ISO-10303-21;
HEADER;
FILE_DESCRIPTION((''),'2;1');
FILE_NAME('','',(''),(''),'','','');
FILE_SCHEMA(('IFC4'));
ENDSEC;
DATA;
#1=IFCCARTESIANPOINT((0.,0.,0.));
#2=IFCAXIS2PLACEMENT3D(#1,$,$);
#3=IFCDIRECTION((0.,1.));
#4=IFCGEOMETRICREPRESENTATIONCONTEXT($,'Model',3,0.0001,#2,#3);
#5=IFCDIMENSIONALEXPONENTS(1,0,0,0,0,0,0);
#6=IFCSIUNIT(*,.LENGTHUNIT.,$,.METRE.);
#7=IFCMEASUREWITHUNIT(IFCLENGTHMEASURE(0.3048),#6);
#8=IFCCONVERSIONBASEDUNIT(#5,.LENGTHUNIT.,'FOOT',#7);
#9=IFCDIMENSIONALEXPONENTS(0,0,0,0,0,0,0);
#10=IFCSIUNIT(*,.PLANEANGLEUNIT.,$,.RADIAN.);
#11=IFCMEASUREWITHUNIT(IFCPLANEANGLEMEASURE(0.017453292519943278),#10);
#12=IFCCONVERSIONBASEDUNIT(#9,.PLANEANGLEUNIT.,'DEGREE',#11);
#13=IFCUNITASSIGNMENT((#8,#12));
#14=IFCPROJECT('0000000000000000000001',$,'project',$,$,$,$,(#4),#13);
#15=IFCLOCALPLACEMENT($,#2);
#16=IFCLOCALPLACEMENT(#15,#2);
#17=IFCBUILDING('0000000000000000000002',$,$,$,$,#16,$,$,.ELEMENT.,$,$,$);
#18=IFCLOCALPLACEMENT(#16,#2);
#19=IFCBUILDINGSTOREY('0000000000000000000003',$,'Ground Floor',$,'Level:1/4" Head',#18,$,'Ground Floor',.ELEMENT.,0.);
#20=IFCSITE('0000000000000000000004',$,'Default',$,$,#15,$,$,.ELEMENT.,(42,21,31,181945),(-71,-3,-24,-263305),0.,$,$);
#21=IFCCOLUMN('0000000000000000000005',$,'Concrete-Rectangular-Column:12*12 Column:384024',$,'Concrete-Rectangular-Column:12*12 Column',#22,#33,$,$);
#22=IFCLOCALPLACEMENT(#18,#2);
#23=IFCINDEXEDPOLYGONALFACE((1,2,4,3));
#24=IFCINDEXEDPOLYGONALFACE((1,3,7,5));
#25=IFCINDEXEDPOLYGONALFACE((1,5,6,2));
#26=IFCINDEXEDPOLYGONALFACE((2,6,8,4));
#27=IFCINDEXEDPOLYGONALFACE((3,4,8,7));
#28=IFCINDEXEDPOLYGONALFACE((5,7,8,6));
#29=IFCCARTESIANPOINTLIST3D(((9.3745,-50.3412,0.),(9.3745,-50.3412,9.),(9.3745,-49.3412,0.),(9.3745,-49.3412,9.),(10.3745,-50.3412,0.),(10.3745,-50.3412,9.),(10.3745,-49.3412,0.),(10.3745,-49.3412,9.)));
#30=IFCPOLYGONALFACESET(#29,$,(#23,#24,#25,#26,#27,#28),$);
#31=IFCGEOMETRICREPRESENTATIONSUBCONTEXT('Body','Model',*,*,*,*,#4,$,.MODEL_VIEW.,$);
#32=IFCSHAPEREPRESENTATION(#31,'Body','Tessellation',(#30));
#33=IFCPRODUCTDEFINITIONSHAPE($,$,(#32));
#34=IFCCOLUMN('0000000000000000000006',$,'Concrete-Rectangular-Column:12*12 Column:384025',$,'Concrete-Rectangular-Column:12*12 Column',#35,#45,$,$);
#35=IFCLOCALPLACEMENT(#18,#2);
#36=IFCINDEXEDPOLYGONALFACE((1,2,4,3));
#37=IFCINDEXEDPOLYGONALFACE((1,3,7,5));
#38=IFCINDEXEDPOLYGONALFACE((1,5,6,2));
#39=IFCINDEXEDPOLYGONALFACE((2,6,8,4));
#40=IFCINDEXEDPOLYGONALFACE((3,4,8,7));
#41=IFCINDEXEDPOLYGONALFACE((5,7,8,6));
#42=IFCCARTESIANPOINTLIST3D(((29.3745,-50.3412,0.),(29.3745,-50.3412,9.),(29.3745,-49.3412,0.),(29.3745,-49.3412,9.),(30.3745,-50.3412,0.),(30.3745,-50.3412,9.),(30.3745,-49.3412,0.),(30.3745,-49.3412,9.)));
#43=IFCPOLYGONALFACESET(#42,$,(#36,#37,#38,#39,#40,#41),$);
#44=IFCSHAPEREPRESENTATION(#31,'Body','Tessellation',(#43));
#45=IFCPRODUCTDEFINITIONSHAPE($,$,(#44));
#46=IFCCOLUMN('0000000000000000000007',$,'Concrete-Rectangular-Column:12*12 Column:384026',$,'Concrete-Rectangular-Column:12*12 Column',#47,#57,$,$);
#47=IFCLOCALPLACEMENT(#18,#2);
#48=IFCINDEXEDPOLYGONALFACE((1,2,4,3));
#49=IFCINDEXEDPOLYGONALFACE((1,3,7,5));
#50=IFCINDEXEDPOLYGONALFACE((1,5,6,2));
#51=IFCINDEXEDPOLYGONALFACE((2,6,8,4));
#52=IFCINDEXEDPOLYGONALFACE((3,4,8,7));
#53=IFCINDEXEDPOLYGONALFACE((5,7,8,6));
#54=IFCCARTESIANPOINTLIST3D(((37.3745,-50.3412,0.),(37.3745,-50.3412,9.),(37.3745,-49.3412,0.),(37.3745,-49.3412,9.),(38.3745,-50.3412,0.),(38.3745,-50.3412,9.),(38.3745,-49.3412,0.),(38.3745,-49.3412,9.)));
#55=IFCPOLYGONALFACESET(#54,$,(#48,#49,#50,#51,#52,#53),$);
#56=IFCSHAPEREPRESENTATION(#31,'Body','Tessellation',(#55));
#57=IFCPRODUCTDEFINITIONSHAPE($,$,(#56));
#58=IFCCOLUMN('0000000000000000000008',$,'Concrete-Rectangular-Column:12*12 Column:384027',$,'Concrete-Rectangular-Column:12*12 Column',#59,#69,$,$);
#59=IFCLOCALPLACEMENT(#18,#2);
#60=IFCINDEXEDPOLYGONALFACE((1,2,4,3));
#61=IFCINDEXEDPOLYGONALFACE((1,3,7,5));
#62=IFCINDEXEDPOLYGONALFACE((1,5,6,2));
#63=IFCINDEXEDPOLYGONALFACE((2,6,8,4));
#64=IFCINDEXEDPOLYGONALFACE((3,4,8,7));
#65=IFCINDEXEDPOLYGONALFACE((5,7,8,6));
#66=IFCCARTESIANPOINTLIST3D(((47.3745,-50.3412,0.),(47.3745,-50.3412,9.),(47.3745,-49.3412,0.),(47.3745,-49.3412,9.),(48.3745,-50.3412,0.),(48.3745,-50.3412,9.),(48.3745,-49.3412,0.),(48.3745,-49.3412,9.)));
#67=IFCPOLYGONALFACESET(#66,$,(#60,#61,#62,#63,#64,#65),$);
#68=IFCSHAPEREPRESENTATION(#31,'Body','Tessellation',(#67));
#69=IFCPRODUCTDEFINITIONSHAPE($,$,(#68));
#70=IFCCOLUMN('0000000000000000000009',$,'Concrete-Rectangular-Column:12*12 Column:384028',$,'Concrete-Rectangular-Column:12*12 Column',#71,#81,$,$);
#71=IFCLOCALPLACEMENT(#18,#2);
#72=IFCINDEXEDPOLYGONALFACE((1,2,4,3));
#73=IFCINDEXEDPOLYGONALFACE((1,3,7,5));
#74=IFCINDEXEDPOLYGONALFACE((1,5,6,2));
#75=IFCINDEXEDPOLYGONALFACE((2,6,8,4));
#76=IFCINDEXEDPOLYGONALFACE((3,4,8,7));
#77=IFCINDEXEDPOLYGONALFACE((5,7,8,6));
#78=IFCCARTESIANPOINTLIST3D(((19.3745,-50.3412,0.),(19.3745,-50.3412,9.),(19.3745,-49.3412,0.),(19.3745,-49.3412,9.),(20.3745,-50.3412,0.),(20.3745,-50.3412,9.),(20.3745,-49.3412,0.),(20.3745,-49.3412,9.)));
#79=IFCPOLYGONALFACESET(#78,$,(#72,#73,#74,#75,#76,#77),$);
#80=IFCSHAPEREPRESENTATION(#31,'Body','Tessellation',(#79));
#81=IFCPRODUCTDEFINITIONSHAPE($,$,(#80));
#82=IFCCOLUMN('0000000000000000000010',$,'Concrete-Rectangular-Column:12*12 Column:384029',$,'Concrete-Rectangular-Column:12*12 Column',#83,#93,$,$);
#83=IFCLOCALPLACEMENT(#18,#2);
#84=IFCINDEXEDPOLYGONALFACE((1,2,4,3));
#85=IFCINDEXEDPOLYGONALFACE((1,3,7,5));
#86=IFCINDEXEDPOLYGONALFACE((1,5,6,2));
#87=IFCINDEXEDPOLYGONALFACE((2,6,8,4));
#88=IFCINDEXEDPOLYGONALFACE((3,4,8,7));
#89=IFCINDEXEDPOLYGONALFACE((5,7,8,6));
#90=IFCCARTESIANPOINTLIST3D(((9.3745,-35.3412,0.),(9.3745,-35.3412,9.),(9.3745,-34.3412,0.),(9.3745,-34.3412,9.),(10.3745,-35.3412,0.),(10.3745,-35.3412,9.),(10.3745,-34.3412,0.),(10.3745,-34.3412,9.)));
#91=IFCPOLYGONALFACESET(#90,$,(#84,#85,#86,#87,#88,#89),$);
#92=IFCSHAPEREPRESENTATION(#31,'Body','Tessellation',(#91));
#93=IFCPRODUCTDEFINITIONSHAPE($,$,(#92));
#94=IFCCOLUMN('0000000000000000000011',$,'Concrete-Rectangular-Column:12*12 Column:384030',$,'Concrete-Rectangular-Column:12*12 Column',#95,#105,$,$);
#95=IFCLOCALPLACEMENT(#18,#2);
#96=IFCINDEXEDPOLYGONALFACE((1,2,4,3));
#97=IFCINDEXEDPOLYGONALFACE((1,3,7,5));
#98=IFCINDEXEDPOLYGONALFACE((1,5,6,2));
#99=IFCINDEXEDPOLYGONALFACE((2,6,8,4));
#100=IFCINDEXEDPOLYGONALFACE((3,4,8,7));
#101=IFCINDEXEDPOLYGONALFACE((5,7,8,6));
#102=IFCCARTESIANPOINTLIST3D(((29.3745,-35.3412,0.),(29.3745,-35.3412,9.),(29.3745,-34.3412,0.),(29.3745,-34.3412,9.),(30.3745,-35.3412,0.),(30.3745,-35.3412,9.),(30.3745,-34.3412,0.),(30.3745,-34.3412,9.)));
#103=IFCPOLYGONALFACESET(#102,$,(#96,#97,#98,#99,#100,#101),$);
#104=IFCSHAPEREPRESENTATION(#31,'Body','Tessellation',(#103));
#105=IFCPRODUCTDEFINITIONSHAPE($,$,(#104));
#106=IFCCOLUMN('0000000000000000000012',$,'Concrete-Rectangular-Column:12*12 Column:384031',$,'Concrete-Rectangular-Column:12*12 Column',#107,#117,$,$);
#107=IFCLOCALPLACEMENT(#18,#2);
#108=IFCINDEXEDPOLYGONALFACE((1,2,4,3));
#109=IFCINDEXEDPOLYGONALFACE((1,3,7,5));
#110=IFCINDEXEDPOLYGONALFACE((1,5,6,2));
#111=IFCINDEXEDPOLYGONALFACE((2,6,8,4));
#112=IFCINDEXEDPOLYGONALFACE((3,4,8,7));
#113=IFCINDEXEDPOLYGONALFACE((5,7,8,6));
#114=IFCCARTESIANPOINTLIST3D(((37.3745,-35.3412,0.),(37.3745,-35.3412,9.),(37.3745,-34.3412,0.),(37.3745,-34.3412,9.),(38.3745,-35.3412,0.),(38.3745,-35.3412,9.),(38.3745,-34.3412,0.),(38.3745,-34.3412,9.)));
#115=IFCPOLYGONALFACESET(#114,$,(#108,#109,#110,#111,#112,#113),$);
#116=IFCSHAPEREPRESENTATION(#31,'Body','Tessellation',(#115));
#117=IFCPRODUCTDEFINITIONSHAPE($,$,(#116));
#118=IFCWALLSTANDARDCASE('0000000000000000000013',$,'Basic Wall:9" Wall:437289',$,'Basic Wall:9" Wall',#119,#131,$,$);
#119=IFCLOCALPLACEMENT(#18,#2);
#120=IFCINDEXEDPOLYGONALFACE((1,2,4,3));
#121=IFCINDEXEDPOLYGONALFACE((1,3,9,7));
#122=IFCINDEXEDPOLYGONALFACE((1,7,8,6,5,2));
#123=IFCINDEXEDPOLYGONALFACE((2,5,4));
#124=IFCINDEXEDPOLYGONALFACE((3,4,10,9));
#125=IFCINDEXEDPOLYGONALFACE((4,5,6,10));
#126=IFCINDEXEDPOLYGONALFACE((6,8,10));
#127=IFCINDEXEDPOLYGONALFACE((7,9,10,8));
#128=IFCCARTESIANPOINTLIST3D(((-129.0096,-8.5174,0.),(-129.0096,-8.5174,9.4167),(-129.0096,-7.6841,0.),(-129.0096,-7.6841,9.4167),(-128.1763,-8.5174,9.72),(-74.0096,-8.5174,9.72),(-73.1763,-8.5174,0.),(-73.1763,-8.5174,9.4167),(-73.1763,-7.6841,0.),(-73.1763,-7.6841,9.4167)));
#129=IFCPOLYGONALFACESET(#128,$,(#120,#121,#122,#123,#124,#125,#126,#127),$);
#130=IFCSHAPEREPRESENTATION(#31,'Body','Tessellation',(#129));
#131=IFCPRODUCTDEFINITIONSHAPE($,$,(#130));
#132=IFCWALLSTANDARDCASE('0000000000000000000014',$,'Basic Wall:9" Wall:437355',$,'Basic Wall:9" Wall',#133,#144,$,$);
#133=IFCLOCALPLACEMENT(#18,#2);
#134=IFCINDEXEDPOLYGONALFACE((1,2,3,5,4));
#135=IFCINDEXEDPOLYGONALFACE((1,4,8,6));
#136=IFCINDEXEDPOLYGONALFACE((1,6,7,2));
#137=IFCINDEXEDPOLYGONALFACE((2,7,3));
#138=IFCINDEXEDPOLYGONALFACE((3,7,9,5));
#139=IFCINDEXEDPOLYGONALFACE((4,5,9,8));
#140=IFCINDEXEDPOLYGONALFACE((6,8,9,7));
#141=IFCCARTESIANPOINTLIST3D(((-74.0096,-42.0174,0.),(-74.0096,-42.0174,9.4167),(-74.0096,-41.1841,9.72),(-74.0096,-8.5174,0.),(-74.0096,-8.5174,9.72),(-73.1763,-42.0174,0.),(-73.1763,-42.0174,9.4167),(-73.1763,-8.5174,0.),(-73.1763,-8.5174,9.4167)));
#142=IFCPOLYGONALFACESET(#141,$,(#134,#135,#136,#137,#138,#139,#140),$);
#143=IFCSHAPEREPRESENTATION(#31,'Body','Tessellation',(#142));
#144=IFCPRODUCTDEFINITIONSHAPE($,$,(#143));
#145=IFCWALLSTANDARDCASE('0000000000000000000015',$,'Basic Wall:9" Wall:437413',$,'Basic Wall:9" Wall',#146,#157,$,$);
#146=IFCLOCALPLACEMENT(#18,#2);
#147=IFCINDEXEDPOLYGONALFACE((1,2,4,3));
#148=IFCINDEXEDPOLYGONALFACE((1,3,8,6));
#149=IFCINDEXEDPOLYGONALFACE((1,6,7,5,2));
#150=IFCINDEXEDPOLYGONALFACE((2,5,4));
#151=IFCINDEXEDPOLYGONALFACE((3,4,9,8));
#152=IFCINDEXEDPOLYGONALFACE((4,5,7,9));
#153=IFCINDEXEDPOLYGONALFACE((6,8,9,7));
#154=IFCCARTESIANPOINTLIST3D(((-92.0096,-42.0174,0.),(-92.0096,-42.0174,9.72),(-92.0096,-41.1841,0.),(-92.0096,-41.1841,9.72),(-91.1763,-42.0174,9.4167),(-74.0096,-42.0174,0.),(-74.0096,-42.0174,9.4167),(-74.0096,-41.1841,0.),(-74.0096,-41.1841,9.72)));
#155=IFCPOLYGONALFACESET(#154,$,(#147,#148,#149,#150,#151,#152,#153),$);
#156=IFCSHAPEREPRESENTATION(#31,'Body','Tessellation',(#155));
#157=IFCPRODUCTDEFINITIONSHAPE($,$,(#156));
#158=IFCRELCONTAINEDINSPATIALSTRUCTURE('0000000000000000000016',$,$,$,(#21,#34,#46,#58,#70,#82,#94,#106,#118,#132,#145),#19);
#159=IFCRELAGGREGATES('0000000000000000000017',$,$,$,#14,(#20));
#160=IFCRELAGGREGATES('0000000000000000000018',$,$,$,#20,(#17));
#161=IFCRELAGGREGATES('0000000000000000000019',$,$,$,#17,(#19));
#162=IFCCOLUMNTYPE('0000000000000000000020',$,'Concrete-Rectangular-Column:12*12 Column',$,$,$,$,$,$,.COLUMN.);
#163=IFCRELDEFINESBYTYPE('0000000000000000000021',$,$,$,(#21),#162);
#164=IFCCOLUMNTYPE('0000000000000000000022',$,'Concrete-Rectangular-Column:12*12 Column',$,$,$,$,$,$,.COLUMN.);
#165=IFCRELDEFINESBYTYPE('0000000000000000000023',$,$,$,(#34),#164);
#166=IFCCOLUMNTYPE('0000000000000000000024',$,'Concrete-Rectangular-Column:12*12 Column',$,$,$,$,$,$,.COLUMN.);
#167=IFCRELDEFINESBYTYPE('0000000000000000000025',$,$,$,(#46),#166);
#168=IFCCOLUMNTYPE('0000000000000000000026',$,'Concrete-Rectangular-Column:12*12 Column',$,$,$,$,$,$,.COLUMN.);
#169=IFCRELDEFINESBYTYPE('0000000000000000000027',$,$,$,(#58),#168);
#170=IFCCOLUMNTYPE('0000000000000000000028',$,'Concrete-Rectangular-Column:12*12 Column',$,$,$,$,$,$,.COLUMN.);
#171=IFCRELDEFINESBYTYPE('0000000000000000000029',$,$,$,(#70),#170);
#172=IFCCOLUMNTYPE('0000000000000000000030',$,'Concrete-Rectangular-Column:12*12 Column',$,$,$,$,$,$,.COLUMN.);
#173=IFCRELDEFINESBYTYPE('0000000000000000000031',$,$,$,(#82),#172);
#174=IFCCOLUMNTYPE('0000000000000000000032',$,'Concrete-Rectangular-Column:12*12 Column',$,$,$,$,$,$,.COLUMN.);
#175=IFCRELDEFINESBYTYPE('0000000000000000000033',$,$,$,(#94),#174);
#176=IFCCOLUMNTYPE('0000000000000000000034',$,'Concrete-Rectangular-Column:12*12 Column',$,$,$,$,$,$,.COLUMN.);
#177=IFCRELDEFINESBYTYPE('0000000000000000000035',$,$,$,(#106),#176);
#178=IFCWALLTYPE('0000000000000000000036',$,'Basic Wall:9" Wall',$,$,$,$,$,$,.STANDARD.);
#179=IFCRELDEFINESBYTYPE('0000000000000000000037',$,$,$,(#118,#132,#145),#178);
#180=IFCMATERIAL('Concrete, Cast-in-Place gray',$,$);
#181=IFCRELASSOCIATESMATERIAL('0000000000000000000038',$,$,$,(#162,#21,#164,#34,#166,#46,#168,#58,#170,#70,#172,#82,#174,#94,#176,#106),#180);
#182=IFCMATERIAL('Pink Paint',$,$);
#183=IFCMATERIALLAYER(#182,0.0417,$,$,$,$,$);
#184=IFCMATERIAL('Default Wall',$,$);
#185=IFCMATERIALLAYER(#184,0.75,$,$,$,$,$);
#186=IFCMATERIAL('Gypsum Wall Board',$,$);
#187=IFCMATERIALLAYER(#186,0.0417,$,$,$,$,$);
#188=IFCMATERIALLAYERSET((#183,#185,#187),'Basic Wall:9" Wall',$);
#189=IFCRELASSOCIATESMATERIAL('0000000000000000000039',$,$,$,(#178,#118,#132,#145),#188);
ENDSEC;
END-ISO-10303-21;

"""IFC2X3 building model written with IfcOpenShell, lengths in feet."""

from ifc_helpers import new_model, entity, si_unit, converted_unit, direction, frame, frame_2d, origin, origin_2d_with_axis, place, context, subcontext, project, spatial, polyline, rectangle, extrude, clip, bounded_halfspace, source, transform, mapped, material, layer, layer_set, layer_usage, type_object, type_shapes, element, save


model = new_model("IFC2X3")

# Units and contexts
model_context = context("Model", 3, precision=0.0001, world=origin(), true_north=direction((0.0, 1.0)))
body_context = subcontext(model_context, "Body", "Model", "MODEL_VIEW")
ifc_project = project(units=[converted_unit("LENGTHUNIT", "FOOT", entity("IfcLengthMeasure", 0.3048), si_unit("LENGTHUNIT", "METRE"), dimensions=[1, 0, 0, 0, 0, 0, 0]), converted_unit("PLANEANGLEUNIT", "DEGREE", entity("IfcPlaneAngleMeasure", 0.017453292519943278), si_unit("PLANEANGLEUNIT", "RADIAN"), dimensions=[0, 0, 0, 0, 0, 0, 0])], contexts=[model_context])

# Site, building, storey
site_placement = place(None, origin())
site = spatial("IfcSite", under=ifc_project, at=site_placement, Name="Default", CompositionType="ELEMENT", RefLatitude=(42, 21, 31, 181945), RefLongitude=(-71, -3, -24, -263305), RefElevation=0.0)
building_placement = place(site_placement, origin())
building = spatial("IfcBuilding", under=site, at=building_placement, CompositionType="ELEMENT")
storey_placement = place(building_placement, origin())
storey = spatial("IfcBuildingStorey", under=building, at=storey_placement, Name="Ground Floor", ObjectType="Level:1/4\" Head", LongName="Ground Floor", CompositionType="ELEMENT", Elevation=0.0)

# Columns
ifc_material_1 = material(Name="Concrete, Cast-in-Place gray")
column_type_1 = type_object("IfcColumnType", Name="Concrete-Rectangular-Column:12*12 Column", PredefinedType="COLUMN", material=ifc_material_1)
shared_shape_1 = source(origin(), body_context, "Body", "SweptSolid", [
    extrude(rectangle(XDim=1.0, YDim=1.0, at=origin_2d_with_axis()), frame((9.8745, -49.8412, 0.0), z_axis=(0.0, 0.0, 1.0), x_axis=(-1.0, 0.0, 0.0)), (0.0, 0.0, 1.0), 9.0),
])
type_shapes(column_type_1, [shared_shape_1])
column_1_placement = place(storey_placement, origin())
element("IfcColumn", 1, at=column_1_placement, inside=storey, type_object=column_type_1, material=ifc_material_1, Name="Concrete-Rectangular-Column:12*12 Column:384024", ObjectType="Concrete-Rectangular-Column:12*12 Column", context=body_context, shape_type="MappedRepresentation", body=[
    mapped(shared_shape_1, transform((0.0, 0.0, 0.0), scale=1.0)),
])
column_type_2 = type_object("IfcColumnType", Name="Concrete-Rectangular-Column:12*12 Column", PredefinedType="COLUMN", material=ifc_material_1)
shared_shape_2 = source(origin(), body_context, "Body", "SweptSolid", [
    extrude(rectangle(XDim=1.0, YDim=1.0, at=frame_2d((0.0, 0.0), x_axis=(1.0, 0.0))), frame((29.8745, -49.8412, 0.0), z_axis=(0.0, 0.0, 1.0), x_axis=(-1.0, 0.0, 0.0)), (0.0, 0.0, 1.0), 9.0),
])
type_shapes(column_type_2, [shared_shape_2])
column_2_placement = place(storey_placement, origin())
element("IfcColumn", 2, at=column_2_placement, inside=storey, type_object=column_type_2, material=ifc_material_1, Name="Concrete-Rectangular-Column:12*12 Column:384025", ObjectType="Concrete-Rectangular-Column:12*12 Column", context=body_context, shape_type="MappedRepresentation", body=[
    mapped(shared_shape_2, transform((0.0, 0.0, 0.0), scale=1.0)),
])
column_type_3 = type_object("IfcColumnType", Name="Concrete-Rectangular-Column:12*12 Column", PredefinedType="COLUMN", material=ifc_material_1)
shared_shape_3 = source(origin(), body_context, "Body", "SweptSolid", [
    extrude(rectangle(XDim=1.0, YDim=1.0, at=origin_2d_with_axis()), frame((37.8745, -49.8412, 0.0), z_axis=(0.0, 0.0, 1.0), x_axis=(-1.0, 0.0, 0.0)), (0.0, 0.0, 1.0), 9.0),
])
type_shapes(column_type_3, [shared_shape_3])
column_3_placement = place(storey_placement, origin())
element("IfcColumn", 3, at=column_3_placement, inside=storey, type_object=column_type_3, material=ifc_material_1, Name="Concrete-Rectangular-Column:12*12 Column:384026", ObjectType="Concrete-Rectangular-Column:12*12 Column", context=body_context, shape_type="MappedRepresentation", body=[
    mapped(shared_shape_3, transform((0.0, 0.0, 0.0), scale=1.0)),
])
column_type_4 = type_object("IfcColumnType", Name="Concrete-Rectangular-Column:12*12 Column", PredefinedType="COLUMN", material=ifc_material_1)
shared_shape_4 = source(origin(), body_context, "Body", "SweptSolid", [
    extrude(rectangle(XDim=1.0, YDim=1.0, at=origin_2d_with_axis()), frame((47.8745, -49.8412, 0.0), z_axis=(0.0, 0.0, 1.0), x_axis=(-1.0, 0.0, 0.0)), (0.0, 0.0, 1.0), 9.0),
])
type_shapes(column_type_4, [shared_shape_4])
column_4_placement = place(storey_placement, origin())
element("IfcColumn", 4, at=column_4_placement, inside=storey, type_object=column_type_4, material=ifc_material_1, Name="Concrete-Rectangular-Column:12*12 Column:384027", ObjectType="Concrete-Rectangular-Column:12*12 Column", context=body_context, shape_type="MappedRepresentation", body=[
    mapped(shared_shape_4, transform((0.0, 0.0, 0.0), scale=1.0)),
])
column_type_5 = type_object("IfcColumnType", Name="Concrete-Rectangular-Column:12*12 Column", PredefinedType="COLUMN", material=ifc_material_1)
shared_shape_5 = source(origin(), body_context, "Body", "SweptSolid", [
    extrude(rectangle(XDim=1.0, YDim=1.0, at=frame_2d((0.0, 0.0), x_axis=(1.0, 0.0))), frame((19.8745, -49.8412, 0.0), z_axis=(0.0, 0.0, 1.0), x_axis=(-1.0, 0.0, 0.0)), (0.0, 0.0, 1.0), 9.0),
])
type_shapes(column_type_5, [shared_shape_5])
column_5_placement = place(storey_placement, origin())
element("IfcColumn", 5, at=column_5_placement, inside=storey, type_object=column_type_5, material=ifc_material_1, Name="Concrete-Rectangular-Column:12*12 Column:384028", ObjectType="Concrete-Rectangular-Column:12*12 Column", context=body_context, shape_type="MappedRepresentation", body=[
    mapped(shared_shape_5, transform((0.0, 0.0, 0.0), scale=1.0)),
])
column_type_6 = type_object("IfcColumnType", Name="Concrete-Rectangular-Column:12*12 Column", PredefinedType="COLUMN", material=ifc_material_1)
shared_shape_6 = source(origin(), body_context, "Body", "SweptSolid", [
    extrude(rectangle(XDim=1.0, YDim=1.0, at=origin_2d_with_axis()), frame((9.8745, -34.8412, 0.0), z_axis=(0.0, 0.0, 1.0), x_axis=(-1.0, 0.0, 0.0)), (0.0, 0.0, 1.0), 9.0),
])
type_shapes(column_type_6, [shared_shape_6])
column_6_placement = place(storey_placement, origin())
element("IfcColumn", 6, at=column_6_placement, inside=storey, type_object=column_type_6, material=ifc_material_1, Name="Concrete-Rectangular-Column:12*12 Column:384029", ObjectType="Concrete-Rectangular-Column:12*12 Column", context=body_context, shape_type="MappedRepresentation", body=[
    mapped(shared_shape_6, transform((0.0, 0.0, 0.0), scale=1.0)),
])
column_type_7 = type_object("IfcColumnType", Name="Concrete-Rectangular-Column:12*12 Column", PredefinedType="COLUMN", material=ifc_material_1)
shared_shape_7 = source(origin(), body_context, "Body", "SweptSolid", [
    extrude(rectangle(XDim=1.0, YDim=1.0, at=frame_2d((0.0, 0.0), x_axis=(1.0, 0.0))), frame((29.8745, -34.8412, 0.0), z_axis=(0.0, 0.0, 1.0), x_axis=(-1.0, 0.0, 0.0)), (0.0, 0.0, 1.0), 9.0),
])
type_shapes(column_type_7, [shared_shape_7])
column_7_placement = place(storey_placement, origin())
element("IfcColumn", 7, at=column_7_placement, inside=storey, type_object=column_type_7, material=ifc_material_1, Name="Concrete-Rectangular-Column:12*12 Column:384030", ObjectType="Concrete-Rectangular-Column:12*12 Column", context=body_context, shape_type="MappedRepresentation", body=[
    mapped(shared_shape_7, transform((0.0, 0.0, 0.0), scale=1.0)),
])
column_type_8 = type_object("IfcColumnType", Name="Concrete-Rectangular-Column:12*12 Column", PredefinedType="COLUMN", material=ifc_material_1)
shared_shape_8 = source(origin(), body_context, "Body", "SweptSolid", [
    extrude(rectangle(XDim=1.0, YDim=1.0, at=origin_2d_with_axis()), frame((37.8745, -34.8412, 0.0), z_axis=(0.0, 0.0, 1.0), x_axis=(-1.0, 0.0, 0.0)), (0.0, 0.0, 1.0), 9.0),
])
type_shapes(column_type_8, [shared_shape_8])
column_8_placement = place(storey_placement, origin())
element("IfcColumn", 8, at=column_8_placement, inside=storey, type_object=column_type_8, material=ifc_material_1, Name="Concrete-Rectangular-Column:12*12 Column:384031", ObjectType="Concrete-Rectangular-Column:12*12 Column", context=body_context, shape_type="MappedRepresentation", body=[
    mapped(shared_shape_8, transform((0.0, 0.0, 0.0), scale=1.0)),
])

# Walls
ifc_material_2 = material(Name="Pink Paint")
ifc_layer_1 = layer(ifc_material_2, 0.0417)
ifc_material_3 = material(Name="Default Wall")
ifc_layer_2 = layer(ifc_material_3, 0.75)
ifc_material_4 = material(Name="Gypsum Wall Board")
ifc_layer_3 = layer(ifc_material_4, 0.0417)
ifc_layer_set_1 = layer_set([ifc_layer_1, ifc_layer_2, ifc_layer_3], Name="Basic Wall:9\" Wall")
ifc_layer_usage_1 = layer_usage(ifc_layer_set_1, "AXIS2", "NEGATIVE", 0.4167)
wall_type_1 = type_object("IfcWallType", Name="Basic Wall:9\" Wall", PredefinedType="STANDARD", material=ifc_layer_set_1)
wall_1_placement = place(storey_placement, frame((-129.0096, -8.1008, 0.0)))
element("IfcWallStandardCase", 9, at=wall_1_placement, inside=storey, type_object=wall_type_1, material=ifc_layer_usage_1, Name="Basic Wall:9\" Wall:437289", ObjectType="Basic Wall:9\" Wall", context=body_context, shape_type="Clipping", body=[
    clip(clip(clip(extrude(rectangle(XDim=55.8333, YDim=0.8333, at=frame_2d((27.9167, 0.0), x_axis=(-1.0, 0.0))), origin(), (0.0, 0.0, 1.0), 9.72), bounded_halfspace(frame((0.0, -0.4167, 9.4167), z_axis=(-0.34202, 0.0, 0.939693), x_axis=(0.0, -1.0, 0.0)), False, frame((0.0, -0.4167, 9.4167)), polyline([(0.0, 0.0), (0.8333, 0.0), (0.0, 0.8333), (0.0, 0.0)]))), bounded_halfspace(frame((55.0, -0.4167, 9.72), z_axis=(0.34202, 0.0, 0.939693), x_axis=(0.0, 1.0, 0.0)), False, frame((55.0, -0.4167, 9.72)), polyline([(0.0, 0.0), (0.8333, 0.0), (0.8333, 0.8333), (0.0, 0.0)]))), bounded_halfspace(frame((0.8333, -0.4167, 9.72), z_axis=(0.0, 0.34202, 0.939693), x_axis=(-1.0, 0.0, 0.0)), False, frame((0.8333, -0.4167, 9.72)), polyline([(0.0, 0.0), (54.1667, 0.0), (55.0, 0.8333), (-0.8333, 0.8333), (0.0, 0.0)]))),
])
wall_2_placement = place(storey_placement, frame((-73.593, -8.5174, 0.0), z_axis=(0.0, 0.0, 1.0), x_axis=(0.0, -1.0, 0.0)))
element("IfcWallStandardCase", 10, at=wall_2_placement, inside=storey, type_object=wall_type_1, material=ifc_layer_usage_1, Name="Basic Wall:9\" Wall:437355", ObjectType="Basic Wall:9\" Wall", context=body_context, shape_type="Clipping", body=[
    clip(clip(extrude(rectangle(XDim=33.5, YDim=0.8333, at=frame_2d((16.75, 0.0), x_axis=(-1.0, 0.0))), origin(), (0.0, 0.0, 1.0), 9.72), bounded_halfspace(frame((0.0, -0.4167, 9.72), z_axis=(0.0, 0.34202, 0.939693), x_axis=(-1.0, 0.0, 0.0)), False, frame((0.0, -0.4167, 9.72)), polyline([(0.0, 0.0), (32.6667, 0.0), (33.5, 0.8333), (0.0, 0.8333), (0.0, 0.0)]))), bounded_halfspace(frame((32.6667, -0.4167, 9.72), z_axis=(0.34202, 0.0, 0.939693), x_axis=(0.0, 1.0, 0.0)), False, frame((32.6667, -0.4167, 9.72)), polyline([(0.0, 0.0), (0.8333, 0.0), (0.8333, 0.8333), (0.0, 0.0)]))),
])
wall_3_placement = place(storey_placement, frame((-74.0096, -41.6008, 0.0), z_axis=(0.0, 0.0, 1.0), x_axis=(-1.0, 0.0, 0.0)))
element("IfcWallStandardCase", 11, at=wall_3_placement, inside=storey, type_object=wall_type_1, material=ifc_layer_usage_1, Name="Basic Wall:9\" Wall:437413", ObjectType="Basic Wall:9\" Wall", context=body_context, shape_type="Clipping", body=[
    clip(clip(extrude(rectangle(XDim=18.0, YDim=0.8333, at=frame_2d((9.0, 0.0), x_axis=(-1.0, 0.0))), origin(), (0.0, 0.0, 1.0), 9.72), bounded_halfspace(frame((18.0, -0.4167, 9.72), z_axis=(-0.34202, 0.0, 0.939693), x_axis=(0.0, -1.0, 0.0)), False, frame((18.0, -0.4167, 9.72)), polyline([(0.0, 0.0), (0.0, 0.8333), (-0.8333, 0.8333), (0.0, 0.0)]))), bounded_halfspace(frame((0.0, -0.4167, 9.72), z_axis=(0.0, 0.34202, 0.939693), x_axis=(-1.0, 0.0, 0.0)), False, frame((0.0, -0.4167, 9.72)), polyline([(0.0, 0.0), (18.0, 0.0), (17.1667, 0.8333), (0.0, 0.8333), (0.0, 0.0)]))),
])

save(model, "model.ifc")
